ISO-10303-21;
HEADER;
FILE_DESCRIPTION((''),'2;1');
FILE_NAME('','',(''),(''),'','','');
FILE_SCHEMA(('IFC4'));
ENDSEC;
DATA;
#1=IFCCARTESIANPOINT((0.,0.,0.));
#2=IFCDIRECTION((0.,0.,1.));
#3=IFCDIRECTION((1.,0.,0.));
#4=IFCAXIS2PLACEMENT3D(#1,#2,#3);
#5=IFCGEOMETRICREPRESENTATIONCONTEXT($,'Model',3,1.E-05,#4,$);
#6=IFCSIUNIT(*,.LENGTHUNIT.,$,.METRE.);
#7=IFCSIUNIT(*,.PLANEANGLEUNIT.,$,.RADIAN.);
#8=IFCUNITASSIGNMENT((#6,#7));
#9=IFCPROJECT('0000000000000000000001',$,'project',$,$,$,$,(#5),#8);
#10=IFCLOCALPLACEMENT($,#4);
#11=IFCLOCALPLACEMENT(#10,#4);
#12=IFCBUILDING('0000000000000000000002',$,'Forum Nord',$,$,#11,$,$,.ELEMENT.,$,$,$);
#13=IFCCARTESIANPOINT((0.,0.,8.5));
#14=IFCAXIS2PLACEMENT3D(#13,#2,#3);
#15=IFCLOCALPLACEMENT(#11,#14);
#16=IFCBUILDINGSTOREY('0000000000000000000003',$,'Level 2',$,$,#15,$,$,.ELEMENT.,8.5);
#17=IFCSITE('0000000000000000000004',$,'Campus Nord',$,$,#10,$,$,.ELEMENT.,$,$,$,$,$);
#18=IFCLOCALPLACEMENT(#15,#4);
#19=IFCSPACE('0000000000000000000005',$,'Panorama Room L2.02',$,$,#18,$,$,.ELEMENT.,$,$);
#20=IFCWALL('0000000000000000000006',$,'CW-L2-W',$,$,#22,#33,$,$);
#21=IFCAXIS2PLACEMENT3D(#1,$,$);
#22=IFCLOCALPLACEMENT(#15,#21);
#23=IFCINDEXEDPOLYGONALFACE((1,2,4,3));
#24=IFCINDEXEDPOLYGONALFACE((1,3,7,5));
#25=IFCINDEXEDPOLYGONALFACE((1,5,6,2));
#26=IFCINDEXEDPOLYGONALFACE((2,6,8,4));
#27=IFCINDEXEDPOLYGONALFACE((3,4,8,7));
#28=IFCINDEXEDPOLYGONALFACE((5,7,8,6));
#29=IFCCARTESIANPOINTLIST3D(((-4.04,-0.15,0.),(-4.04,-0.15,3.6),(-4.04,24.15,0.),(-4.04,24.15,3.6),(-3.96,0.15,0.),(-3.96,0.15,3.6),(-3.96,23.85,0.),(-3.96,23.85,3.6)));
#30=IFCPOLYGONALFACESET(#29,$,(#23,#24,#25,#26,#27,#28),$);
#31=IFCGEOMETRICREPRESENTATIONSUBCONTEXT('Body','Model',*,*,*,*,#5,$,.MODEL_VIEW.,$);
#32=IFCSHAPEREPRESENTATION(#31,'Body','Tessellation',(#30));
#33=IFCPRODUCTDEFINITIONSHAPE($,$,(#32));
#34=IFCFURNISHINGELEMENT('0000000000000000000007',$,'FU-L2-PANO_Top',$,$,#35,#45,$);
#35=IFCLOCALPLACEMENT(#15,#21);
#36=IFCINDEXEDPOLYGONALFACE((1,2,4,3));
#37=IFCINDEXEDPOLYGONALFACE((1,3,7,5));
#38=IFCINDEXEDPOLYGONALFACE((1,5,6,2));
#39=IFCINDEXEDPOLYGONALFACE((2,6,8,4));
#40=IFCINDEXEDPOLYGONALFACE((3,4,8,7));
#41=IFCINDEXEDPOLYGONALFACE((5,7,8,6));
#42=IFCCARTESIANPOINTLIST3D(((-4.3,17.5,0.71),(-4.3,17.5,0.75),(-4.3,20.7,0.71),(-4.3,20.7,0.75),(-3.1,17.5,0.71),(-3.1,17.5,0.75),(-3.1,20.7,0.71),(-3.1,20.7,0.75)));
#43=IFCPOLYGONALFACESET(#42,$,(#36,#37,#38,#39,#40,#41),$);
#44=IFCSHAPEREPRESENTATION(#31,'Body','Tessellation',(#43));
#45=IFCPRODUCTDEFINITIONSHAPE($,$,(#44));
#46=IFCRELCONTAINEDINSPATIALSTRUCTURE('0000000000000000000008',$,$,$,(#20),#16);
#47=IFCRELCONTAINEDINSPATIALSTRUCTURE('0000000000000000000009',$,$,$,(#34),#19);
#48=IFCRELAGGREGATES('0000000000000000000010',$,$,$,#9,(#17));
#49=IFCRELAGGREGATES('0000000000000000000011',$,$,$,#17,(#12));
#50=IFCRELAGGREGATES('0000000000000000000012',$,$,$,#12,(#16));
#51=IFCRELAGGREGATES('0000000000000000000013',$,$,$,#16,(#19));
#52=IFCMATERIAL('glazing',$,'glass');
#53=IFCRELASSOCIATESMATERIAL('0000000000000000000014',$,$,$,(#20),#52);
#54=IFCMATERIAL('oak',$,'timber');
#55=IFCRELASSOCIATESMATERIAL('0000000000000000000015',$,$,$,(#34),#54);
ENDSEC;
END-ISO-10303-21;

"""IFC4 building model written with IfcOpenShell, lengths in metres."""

from ifc_helpers import new_model, si_unit, frame, frame_2d, origin_with_axes, place, context, subcontext, project, spatial, polyline, rectangle, outline, extrude, material, element, save


model = new_model("IFC4")

# Units and contexts
model_context = context("Model", 3, precision=1e-05, world=origin_with_axes())
body_context = subcontext(model_context, "Body", "Model", "MODEL_VIEW")
ifc_project = project(units=[si_unit("LENGTHUNIT", "METRE"), si_unit("PLANEANGLEUNIT", "RADIAN")], contexts=[model_context])

# Site, building, storey
site_placement = place(None, origin_with_axes())
site = spatial("IfcSite", under=ifc_project, at=site_placement, Name="Campus Nord", CompositionType="ELEMENT")
building_placement = place(site_placement, origin_with_axes())
building = spatial("IfcBuilding", under=site, at=building_placement, Name="Forum Nord", CompositionType="ELEMENT")
storey_placement = place(building_placement, frame((0.0, 0.0, 8.5), z_axis=(0.0, 0.0, 1.0), x_axis=(1.0, 0.0, 0.0)))
storey = spatial("IfcBuildingStorey", under=building, at=storey_placement, Name="Level 2", CompositionType="ELEMENT", Elevation=8.5)

# Wall
ifc_material_1 = material(Name="glazing", Category="glass")
wall_1_placement = place(storey_placement, frame((-4.0, 24.0, 0.0), z_axis=(0.0, 0.0, 1.0), x_axis=(0.0, -1.0, 0.0)))
element("IfcWall", 1, at=wall_1_placement, inside=storey, material=ifc_material_1, Name="CW-L2-W", context=body_context, shape_type="SweptSolid", body=[
    extrude(outline(polyline([(-0.15, -0.04), (24.15, -0.04), (23.85, 0.04), (0.15, 0.04), (-0.15, -0.04)])), origin_with_axes(), (0.0, 0.0, 1.0), 3.6),
])

# Shared definitions
space_placement = place(storey_placement, origin_with_axes())
space = spatial("IfcSpace", under=storey, at=space_placement, Name="Panorama Room L2.02", CompositionType="ELEMENT")

# Furnishing element
ifc_material_2 = material(Name="oak", Category="timber")
furnishing_1_placement = place(storey_placement, frame((-2.6, 17.5, 0.0), z_axis=(0.0, 0.0, 1.0), x_axis=(0.0, 1.0, 0.0)))
element("IfcFurnishingElement", 2, at=furnishing_1_placement, inside=space, material=ifc_material_2, Name="FU-L2-PANO_Top", context=body_context, shape_type="SweptSolid", body=[
    extrude(rectangle(XDim=3.2, YDim=1.2, at=frame_2d((1.6, 1.1), x_axis=(1.0, 0.0))), frame((0.0, 0.0, 0.71), z_axis=(0.0, 0.0, 1.0), x_axis=(1.0, 0.0, 0.0)), (0.0, 0.0, 1.0), 0.04),
])

save(model, "model.ifc")
